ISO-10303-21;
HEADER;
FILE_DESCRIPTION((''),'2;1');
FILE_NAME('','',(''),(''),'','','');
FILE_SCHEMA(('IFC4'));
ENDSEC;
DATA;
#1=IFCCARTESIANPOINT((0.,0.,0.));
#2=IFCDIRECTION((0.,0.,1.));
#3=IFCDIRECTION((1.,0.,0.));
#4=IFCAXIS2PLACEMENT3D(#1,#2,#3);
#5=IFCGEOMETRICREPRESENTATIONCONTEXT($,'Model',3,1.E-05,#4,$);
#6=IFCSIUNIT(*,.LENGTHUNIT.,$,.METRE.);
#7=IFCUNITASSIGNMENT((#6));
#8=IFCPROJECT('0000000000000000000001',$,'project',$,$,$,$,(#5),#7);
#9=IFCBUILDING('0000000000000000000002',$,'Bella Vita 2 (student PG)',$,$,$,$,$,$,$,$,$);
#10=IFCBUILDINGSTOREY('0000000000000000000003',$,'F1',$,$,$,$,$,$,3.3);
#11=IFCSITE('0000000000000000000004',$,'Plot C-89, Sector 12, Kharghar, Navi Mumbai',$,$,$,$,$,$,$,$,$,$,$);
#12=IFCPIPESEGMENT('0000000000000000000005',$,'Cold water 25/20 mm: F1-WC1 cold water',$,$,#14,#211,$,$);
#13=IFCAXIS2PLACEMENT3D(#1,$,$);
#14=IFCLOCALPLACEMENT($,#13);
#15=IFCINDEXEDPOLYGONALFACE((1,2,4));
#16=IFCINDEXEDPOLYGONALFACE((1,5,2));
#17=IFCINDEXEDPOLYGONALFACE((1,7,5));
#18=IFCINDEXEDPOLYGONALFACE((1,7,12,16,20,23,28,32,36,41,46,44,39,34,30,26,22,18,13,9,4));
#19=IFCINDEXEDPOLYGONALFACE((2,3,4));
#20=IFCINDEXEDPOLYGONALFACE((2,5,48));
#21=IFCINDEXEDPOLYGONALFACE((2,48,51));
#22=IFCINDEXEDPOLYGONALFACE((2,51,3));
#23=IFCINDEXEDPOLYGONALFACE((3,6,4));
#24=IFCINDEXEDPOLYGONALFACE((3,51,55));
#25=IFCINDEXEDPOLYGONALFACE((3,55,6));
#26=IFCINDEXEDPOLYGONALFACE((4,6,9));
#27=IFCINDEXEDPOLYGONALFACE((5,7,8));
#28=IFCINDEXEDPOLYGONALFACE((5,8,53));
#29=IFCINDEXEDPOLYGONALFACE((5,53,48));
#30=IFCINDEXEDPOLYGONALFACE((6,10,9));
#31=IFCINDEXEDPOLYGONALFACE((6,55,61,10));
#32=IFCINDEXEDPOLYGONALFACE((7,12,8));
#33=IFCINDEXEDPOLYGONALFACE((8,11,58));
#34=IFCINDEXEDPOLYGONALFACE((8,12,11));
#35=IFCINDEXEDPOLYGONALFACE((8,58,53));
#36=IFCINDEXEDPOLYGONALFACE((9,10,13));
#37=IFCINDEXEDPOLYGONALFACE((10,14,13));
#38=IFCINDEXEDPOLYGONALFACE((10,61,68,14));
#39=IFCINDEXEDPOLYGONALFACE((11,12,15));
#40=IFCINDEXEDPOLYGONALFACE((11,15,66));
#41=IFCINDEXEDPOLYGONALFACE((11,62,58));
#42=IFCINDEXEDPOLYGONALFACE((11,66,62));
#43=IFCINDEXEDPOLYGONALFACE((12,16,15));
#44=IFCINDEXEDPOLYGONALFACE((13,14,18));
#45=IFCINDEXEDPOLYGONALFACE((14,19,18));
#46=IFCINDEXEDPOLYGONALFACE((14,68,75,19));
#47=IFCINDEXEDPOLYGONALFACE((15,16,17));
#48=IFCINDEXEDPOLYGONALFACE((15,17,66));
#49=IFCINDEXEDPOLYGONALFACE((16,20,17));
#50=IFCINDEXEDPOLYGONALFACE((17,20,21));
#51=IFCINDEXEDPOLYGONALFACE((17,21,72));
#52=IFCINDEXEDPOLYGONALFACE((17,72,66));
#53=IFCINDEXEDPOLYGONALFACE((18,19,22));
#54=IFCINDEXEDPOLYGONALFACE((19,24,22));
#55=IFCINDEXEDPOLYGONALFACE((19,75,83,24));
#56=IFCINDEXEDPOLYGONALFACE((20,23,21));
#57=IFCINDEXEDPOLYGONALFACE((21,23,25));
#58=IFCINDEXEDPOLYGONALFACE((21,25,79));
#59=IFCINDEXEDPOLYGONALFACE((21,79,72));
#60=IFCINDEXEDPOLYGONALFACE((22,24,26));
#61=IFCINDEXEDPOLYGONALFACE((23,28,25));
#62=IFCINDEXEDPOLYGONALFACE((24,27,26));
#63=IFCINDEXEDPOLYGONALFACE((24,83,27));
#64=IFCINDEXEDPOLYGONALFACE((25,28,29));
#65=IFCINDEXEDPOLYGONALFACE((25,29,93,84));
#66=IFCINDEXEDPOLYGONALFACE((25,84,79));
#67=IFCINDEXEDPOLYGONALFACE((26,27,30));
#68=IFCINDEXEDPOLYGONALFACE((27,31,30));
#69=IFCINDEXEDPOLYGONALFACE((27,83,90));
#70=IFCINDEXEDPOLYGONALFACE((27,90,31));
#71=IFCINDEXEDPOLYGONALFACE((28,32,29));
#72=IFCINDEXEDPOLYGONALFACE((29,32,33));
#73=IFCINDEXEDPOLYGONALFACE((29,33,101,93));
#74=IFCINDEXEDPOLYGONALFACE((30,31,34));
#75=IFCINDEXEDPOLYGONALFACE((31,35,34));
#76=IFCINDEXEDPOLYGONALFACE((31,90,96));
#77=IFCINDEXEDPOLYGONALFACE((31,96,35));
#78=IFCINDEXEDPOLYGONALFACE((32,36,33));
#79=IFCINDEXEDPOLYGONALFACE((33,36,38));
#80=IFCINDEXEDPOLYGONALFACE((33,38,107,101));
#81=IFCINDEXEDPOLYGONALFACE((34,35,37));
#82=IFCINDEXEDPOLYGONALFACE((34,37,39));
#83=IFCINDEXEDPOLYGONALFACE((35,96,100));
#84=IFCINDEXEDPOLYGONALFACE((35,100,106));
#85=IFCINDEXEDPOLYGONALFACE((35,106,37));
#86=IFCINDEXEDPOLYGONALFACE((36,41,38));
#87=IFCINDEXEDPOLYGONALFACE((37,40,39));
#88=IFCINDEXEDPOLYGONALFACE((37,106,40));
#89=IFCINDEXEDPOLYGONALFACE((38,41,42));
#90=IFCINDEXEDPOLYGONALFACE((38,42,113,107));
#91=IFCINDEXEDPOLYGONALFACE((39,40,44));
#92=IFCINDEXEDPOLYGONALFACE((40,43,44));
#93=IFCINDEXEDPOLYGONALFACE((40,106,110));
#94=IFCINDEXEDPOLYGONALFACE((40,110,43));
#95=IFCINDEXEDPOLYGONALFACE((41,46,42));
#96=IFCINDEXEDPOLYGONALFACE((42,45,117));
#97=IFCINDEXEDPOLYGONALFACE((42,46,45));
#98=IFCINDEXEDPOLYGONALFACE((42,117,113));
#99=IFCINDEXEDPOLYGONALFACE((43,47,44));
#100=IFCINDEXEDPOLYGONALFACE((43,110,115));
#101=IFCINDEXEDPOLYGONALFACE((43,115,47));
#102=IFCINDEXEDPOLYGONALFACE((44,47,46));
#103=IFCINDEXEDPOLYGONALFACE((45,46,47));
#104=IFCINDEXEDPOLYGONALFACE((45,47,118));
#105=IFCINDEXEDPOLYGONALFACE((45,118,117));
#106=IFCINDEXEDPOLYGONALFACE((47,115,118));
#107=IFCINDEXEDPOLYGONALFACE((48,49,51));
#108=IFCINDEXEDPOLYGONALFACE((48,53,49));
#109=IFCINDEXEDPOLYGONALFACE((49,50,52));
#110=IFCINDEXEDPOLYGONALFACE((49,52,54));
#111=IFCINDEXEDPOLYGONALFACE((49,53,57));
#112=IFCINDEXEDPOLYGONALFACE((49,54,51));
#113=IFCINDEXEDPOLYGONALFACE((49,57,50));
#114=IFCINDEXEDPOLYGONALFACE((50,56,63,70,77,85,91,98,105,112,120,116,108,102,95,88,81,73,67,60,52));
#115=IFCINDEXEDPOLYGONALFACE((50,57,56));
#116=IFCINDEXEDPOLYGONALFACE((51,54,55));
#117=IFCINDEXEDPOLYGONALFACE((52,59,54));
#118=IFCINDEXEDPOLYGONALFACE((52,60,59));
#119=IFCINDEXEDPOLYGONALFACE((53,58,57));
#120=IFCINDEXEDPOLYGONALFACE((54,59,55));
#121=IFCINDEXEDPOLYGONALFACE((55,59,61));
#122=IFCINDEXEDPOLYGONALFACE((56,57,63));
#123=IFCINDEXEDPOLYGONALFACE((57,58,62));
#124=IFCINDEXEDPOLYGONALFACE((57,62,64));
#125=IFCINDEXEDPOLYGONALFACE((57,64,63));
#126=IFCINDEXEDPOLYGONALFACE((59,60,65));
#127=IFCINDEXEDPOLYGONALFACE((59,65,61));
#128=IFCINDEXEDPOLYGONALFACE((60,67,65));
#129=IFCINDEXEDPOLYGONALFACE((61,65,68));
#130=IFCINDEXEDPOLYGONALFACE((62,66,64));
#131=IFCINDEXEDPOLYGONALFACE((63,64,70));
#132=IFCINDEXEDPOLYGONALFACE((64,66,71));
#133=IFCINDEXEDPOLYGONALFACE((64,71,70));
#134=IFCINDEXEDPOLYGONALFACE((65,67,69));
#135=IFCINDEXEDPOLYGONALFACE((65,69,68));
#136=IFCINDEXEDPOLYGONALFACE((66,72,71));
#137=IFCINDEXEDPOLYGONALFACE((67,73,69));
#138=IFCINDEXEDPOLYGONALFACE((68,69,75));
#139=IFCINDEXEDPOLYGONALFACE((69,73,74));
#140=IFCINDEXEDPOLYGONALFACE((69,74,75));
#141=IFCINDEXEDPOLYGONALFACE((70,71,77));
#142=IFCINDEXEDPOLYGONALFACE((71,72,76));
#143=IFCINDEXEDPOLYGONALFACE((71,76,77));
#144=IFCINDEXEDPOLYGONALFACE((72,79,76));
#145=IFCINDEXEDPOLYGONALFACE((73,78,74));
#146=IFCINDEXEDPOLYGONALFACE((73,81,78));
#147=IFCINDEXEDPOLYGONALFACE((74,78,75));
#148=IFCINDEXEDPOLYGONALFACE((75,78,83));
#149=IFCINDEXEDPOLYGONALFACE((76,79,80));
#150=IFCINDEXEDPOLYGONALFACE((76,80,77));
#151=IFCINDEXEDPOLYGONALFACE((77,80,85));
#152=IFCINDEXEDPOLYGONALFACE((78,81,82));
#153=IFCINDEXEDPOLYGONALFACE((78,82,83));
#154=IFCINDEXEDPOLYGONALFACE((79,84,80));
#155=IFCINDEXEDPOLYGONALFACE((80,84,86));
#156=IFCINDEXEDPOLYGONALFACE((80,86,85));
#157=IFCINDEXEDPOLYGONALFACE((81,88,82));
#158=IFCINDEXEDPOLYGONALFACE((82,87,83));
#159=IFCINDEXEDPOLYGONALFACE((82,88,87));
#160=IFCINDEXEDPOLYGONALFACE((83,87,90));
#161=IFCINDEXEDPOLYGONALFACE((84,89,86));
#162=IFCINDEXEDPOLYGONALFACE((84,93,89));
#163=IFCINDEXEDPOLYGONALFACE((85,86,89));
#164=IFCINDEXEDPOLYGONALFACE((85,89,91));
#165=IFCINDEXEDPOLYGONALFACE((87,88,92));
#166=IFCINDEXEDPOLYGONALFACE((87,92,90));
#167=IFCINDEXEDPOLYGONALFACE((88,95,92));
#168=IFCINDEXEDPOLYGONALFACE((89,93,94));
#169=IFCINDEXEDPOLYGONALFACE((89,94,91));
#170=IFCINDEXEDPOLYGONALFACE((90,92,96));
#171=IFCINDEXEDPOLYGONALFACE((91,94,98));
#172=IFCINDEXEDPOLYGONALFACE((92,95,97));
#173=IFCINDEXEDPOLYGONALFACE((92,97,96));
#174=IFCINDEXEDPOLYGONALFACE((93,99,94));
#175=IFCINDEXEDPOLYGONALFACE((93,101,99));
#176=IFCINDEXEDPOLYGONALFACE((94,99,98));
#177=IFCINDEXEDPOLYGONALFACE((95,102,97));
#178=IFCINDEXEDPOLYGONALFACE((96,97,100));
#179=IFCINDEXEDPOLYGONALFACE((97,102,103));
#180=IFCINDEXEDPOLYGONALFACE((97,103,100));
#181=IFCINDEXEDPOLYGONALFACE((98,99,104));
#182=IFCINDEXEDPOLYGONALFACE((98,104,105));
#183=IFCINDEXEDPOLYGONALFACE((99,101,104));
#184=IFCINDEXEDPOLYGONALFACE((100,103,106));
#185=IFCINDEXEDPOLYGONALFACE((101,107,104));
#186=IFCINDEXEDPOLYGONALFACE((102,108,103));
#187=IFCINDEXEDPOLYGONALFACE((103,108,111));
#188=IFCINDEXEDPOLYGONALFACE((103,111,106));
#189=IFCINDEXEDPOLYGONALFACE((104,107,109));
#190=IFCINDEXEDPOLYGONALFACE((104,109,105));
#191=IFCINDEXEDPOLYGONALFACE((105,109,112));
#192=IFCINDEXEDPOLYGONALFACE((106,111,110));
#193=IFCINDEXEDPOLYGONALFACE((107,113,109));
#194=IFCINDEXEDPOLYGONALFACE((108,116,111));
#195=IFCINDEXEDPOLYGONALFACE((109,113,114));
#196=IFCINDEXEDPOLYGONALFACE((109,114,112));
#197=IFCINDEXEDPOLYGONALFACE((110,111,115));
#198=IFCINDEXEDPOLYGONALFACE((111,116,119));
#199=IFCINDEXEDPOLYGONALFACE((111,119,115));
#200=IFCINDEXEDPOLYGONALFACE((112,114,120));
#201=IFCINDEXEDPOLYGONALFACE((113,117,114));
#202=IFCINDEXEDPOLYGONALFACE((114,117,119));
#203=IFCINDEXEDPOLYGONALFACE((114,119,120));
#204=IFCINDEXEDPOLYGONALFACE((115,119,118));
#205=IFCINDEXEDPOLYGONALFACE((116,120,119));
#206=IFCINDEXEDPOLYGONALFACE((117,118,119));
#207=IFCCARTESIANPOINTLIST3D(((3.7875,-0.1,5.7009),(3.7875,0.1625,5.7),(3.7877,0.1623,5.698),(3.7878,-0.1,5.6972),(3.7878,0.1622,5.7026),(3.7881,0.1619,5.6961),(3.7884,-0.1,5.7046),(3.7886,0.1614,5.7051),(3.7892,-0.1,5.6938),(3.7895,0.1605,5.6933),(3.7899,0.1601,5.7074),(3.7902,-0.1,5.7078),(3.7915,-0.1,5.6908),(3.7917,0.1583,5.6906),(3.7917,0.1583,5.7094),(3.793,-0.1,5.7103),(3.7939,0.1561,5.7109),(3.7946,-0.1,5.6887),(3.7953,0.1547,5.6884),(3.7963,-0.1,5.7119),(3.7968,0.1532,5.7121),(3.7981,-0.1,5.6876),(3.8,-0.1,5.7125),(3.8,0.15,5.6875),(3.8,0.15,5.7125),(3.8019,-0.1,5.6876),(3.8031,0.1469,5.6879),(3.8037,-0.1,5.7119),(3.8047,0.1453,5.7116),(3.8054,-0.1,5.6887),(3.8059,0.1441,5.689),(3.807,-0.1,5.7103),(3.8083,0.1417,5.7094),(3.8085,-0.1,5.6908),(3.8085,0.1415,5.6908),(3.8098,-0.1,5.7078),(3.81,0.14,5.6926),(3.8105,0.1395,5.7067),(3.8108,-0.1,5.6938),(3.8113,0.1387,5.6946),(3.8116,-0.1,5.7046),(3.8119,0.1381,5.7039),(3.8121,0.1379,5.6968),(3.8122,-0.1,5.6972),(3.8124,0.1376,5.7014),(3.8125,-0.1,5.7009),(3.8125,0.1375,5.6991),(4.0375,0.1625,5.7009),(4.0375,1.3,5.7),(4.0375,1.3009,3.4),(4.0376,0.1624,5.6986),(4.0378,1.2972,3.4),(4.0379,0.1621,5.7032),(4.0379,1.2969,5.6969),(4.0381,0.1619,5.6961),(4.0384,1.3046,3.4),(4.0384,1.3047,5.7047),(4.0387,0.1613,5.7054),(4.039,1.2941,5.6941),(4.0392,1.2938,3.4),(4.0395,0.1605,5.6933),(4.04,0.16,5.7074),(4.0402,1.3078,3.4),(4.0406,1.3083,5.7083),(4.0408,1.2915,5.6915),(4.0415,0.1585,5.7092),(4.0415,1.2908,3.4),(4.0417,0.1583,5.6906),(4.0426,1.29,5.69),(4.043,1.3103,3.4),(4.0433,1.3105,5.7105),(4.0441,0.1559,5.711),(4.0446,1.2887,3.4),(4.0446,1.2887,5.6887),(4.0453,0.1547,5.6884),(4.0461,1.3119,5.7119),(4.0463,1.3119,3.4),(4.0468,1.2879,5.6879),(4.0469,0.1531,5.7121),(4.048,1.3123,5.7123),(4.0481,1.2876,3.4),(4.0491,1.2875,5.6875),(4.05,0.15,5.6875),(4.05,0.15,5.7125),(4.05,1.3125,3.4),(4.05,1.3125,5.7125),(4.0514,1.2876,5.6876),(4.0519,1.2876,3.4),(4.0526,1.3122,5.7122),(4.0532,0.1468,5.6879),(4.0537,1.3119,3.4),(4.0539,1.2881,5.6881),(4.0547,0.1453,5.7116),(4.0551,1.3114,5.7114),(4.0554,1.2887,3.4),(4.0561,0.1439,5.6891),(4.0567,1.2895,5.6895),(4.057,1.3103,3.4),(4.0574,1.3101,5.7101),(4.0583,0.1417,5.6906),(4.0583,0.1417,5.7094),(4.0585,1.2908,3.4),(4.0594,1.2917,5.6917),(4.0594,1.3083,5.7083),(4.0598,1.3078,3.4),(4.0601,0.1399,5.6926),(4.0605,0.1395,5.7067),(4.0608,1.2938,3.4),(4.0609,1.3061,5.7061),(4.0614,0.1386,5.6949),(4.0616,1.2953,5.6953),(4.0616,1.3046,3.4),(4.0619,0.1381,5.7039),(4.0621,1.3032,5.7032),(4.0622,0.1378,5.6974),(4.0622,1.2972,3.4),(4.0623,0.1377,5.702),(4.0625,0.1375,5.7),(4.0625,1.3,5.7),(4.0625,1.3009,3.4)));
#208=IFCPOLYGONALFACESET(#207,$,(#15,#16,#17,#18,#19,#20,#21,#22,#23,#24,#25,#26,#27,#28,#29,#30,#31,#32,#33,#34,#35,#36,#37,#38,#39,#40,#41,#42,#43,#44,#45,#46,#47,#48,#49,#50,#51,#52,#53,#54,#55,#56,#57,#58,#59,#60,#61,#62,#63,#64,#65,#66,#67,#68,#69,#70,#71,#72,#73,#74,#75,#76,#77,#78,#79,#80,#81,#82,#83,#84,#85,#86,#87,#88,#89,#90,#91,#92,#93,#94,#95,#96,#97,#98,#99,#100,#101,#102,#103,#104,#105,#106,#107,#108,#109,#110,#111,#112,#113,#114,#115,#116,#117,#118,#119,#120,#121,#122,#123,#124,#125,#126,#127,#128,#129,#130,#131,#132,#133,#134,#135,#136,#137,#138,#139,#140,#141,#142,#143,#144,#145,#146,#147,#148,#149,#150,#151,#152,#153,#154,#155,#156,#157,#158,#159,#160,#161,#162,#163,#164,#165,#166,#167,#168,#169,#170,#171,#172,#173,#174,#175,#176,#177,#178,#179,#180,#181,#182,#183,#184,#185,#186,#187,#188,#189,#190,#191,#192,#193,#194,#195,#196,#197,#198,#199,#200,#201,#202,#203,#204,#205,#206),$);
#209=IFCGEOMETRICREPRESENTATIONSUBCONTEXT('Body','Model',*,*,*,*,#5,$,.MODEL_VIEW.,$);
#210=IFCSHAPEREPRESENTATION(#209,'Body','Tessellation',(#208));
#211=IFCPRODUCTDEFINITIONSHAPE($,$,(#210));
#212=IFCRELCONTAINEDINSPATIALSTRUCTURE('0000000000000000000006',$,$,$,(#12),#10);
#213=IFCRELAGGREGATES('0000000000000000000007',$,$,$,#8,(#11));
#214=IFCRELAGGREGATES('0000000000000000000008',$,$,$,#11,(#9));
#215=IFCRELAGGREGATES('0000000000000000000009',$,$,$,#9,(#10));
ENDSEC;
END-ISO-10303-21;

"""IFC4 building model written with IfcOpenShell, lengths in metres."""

from ifc_helpers import new_model, entity, si_unit, origin, origin_with_axes, place, context, subcontext, project, spatial, element, save


model = new_model("IFC4")

# Units and contexts
model_context = context("Model", 3, precision=1e-05, world=origin_with_axes())
body_context = subcontext(model_context, "Body", "Model", "MODEL_VIEW")
ifc_project = project(units=[si_unit("LENGTHUNIT", "METRE")], contexts=[model_context])

# Site, building, storey
site = spatial("IfcSite", under=ifc_project, Name="Plot C-89, Sector 12, Kharghar, Navi Mumbai")
building = spatial("IfcBuilding", under=site, Name="Bella Vita 2 (student PG)")
storey = spatial("IfcBuildingStorey", under=building, Name="F1", Elevation=3.3)

# Pipe segment
pipe_segment_1_placement = place(None, origin())
element("IfcPipeSegment", 1, at=pipe_segment_1_placement, inside=storey, Name="Cold water 25/20 mm: F1-WC1 cold water", context=body_context, shape_type="AdvancedSweptSolid", body=[
    entity("IfcSweptDiskSolid", entity("IfcPolyline", [entity("IfcCartesianPoint", [3.8, -0.1, 5.7]), entity("IfcCartesianPoint", [3.8, 0.15, 5.7]), entity("IfcCartesianPoint", [4.05, 0.15, 5.7]), entity("IfcCartesianPoint", [4.05, 1.3, 5.7]), entity("IfcCartesianPoint", [4.05, 1.3, 3.4])]), 0.0125),
])

save(model, "model.ifc")
